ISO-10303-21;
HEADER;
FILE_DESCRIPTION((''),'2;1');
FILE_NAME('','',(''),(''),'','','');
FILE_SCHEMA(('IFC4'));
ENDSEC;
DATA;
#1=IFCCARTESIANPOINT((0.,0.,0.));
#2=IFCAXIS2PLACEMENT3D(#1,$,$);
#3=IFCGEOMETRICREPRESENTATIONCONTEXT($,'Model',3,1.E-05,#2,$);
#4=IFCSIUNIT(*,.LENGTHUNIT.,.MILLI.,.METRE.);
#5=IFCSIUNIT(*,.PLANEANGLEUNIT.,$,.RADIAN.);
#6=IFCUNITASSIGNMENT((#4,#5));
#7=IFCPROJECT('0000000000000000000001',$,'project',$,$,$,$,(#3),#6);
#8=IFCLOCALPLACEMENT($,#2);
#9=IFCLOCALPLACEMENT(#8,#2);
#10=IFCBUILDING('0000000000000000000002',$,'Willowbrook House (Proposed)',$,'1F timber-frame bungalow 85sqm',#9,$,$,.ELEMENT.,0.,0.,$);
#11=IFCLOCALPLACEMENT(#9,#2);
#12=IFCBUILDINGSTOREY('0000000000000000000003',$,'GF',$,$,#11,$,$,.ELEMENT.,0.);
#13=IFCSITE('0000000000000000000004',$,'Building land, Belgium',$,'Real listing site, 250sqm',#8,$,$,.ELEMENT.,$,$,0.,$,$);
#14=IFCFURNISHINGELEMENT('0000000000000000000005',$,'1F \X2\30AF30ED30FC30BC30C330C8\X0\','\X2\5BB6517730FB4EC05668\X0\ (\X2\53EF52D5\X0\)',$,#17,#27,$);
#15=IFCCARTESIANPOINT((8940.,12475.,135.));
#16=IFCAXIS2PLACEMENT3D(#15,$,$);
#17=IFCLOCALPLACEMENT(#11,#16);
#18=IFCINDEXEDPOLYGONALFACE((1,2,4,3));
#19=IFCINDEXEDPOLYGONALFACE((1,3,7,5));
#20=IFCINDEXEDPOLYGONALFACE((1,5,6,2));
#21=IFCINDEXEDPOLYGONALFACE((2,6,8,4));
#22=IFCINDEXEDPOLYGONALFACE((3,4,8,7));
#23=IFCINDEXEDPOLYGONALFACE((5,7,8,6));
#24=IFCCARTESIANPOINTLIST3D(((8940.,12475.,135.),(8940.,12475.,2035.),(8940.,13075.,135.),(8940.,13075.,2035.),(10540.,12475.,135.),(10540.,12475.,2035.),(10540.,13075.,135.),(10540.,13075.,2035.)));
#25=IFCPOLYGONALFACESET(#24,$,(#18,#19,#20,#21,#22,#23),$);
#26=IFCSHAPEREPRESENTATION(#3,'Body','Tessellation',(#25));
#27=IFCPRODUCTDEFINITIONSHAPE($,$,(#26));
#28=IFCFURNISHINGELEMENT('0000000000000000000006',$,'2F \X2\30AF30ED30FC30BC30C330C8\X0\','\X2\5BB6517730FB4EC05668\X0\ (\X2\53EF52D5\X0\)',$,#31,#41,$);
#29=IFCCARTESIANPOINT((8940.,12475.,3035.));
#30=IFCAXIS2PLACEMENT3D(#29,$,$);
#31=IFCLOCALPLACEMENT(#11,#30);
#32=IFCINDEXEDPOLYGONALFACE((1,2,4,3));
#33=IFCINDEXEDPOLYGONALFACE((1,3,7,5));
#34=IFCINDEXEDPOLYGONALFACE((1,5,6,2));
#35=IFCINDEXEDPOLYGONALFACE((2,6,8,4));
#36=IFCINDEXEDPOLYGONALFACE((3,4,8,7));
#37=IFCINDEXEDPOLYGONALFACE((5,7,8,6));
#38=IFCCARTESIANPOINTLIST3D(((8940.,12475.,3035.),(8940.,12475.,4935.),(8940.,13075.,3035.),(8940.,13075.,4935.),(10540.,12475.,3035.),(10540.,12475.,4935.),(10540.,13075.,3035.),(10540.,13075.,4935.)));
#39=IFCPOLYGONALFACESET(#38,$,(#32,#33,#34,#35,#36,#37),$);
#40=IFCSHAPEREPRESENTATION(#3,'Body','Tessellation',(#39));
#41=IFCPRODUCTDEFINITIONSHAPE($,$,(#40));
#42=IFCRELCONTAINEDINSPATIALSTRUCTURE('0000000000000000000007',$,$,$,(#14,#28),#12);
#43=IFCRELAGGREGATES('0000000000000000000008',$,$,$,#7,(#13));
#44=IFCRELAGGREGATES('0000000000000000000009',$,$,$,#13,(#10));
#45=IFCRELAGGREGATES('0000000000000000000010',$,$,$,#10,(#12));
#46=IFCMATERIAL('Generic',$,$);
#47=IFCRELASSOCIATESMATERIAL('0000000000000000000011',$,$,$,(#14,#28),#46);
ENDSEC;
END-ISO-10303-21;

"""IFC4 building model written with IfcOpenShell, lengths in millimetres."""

from ifc_helpers import new_model, si_unit, frame, frame_2d, origin, place, context, project, spatial, rectangle, extrude, material, element, save


model = new_model("IFC4")

# Units and contexts
model_context = context("Model", 3, precision=1e-05, world=origin())
ifc_project = project(units=[si_unit("LENGTHUNIT", "METRE", prefix="MILLI"), si_unit("PLANEANGLEUNIT", "RADIAN")], contexts=[model_context])

# Site, building, storey
site_placement = place(None, origin())
site = spatial("IfcSite", under=ifc_project, at=site_placement, Name="Building land, Belgium", ObjectType="Real listing site, 250sqm", CompositionType="ELEMENT", RefElevation=0.0)
building_placement = place(site_placement, origin())
building = spatial("IfcBuilding", under=site, at=building_placement, Name="Willowbrook House (Proposed)", ObjectType="1F timber-frame bungalow 85sqm", CompositionType="ELEMENT", ElevationOfRefHeight=0.0, ElevationOfTerrain=0.0)
storey_placement = place(building_placement, origin())
storey = spatial("IfcBuildingStorey", under=building, at=storey_placement, Name="GF", CompositionType="ELEMENT", Elevation=0.0)

# Shared definitions
ifc_material_1 = material(Name="Generic")

# Furnishing elements
furnishing_1_placement = place(storey_placement, frame((8940.0, 12475.0, 135.0)))
element("IfcFurnishingElement", 1, at=furnishing_1_placement, inside=storey, material=ifc_material_1, Name="1F クローゼット", Description="家具・什器 (可動)", context=model_context, shape_type="SweptSolid", body=[
    extrude(rectangle(XDim=1600.0, YDim=600.0, at=frame_2d((800.0, 300.0))), frame((8940.0, 12475.0, 135.0)), (0.0, 0.0, 1.0), 1900.0),
])
furnishing_2_placement = place(storey_placement, frame((8940.0, 12475.0, 3035.0)))
element("IfcFurnishingElement", 2, at=furnishing_2_placement, inside=storey, material=ifc_material_1, Name="2F クローゼット", Description="家具・什器 (可動)", context=model_context, shape_type="SweptSolid", body=[
    extrude(rectangle(XDim=1600.0, YDim=600.0, at=frame_2d((800.0, 300.0))), frame((8940.0, 12475.0, 3035.0)), (0.0, 0.0, 1.0), 1900.0),
])

save(model, "model.ifc")
